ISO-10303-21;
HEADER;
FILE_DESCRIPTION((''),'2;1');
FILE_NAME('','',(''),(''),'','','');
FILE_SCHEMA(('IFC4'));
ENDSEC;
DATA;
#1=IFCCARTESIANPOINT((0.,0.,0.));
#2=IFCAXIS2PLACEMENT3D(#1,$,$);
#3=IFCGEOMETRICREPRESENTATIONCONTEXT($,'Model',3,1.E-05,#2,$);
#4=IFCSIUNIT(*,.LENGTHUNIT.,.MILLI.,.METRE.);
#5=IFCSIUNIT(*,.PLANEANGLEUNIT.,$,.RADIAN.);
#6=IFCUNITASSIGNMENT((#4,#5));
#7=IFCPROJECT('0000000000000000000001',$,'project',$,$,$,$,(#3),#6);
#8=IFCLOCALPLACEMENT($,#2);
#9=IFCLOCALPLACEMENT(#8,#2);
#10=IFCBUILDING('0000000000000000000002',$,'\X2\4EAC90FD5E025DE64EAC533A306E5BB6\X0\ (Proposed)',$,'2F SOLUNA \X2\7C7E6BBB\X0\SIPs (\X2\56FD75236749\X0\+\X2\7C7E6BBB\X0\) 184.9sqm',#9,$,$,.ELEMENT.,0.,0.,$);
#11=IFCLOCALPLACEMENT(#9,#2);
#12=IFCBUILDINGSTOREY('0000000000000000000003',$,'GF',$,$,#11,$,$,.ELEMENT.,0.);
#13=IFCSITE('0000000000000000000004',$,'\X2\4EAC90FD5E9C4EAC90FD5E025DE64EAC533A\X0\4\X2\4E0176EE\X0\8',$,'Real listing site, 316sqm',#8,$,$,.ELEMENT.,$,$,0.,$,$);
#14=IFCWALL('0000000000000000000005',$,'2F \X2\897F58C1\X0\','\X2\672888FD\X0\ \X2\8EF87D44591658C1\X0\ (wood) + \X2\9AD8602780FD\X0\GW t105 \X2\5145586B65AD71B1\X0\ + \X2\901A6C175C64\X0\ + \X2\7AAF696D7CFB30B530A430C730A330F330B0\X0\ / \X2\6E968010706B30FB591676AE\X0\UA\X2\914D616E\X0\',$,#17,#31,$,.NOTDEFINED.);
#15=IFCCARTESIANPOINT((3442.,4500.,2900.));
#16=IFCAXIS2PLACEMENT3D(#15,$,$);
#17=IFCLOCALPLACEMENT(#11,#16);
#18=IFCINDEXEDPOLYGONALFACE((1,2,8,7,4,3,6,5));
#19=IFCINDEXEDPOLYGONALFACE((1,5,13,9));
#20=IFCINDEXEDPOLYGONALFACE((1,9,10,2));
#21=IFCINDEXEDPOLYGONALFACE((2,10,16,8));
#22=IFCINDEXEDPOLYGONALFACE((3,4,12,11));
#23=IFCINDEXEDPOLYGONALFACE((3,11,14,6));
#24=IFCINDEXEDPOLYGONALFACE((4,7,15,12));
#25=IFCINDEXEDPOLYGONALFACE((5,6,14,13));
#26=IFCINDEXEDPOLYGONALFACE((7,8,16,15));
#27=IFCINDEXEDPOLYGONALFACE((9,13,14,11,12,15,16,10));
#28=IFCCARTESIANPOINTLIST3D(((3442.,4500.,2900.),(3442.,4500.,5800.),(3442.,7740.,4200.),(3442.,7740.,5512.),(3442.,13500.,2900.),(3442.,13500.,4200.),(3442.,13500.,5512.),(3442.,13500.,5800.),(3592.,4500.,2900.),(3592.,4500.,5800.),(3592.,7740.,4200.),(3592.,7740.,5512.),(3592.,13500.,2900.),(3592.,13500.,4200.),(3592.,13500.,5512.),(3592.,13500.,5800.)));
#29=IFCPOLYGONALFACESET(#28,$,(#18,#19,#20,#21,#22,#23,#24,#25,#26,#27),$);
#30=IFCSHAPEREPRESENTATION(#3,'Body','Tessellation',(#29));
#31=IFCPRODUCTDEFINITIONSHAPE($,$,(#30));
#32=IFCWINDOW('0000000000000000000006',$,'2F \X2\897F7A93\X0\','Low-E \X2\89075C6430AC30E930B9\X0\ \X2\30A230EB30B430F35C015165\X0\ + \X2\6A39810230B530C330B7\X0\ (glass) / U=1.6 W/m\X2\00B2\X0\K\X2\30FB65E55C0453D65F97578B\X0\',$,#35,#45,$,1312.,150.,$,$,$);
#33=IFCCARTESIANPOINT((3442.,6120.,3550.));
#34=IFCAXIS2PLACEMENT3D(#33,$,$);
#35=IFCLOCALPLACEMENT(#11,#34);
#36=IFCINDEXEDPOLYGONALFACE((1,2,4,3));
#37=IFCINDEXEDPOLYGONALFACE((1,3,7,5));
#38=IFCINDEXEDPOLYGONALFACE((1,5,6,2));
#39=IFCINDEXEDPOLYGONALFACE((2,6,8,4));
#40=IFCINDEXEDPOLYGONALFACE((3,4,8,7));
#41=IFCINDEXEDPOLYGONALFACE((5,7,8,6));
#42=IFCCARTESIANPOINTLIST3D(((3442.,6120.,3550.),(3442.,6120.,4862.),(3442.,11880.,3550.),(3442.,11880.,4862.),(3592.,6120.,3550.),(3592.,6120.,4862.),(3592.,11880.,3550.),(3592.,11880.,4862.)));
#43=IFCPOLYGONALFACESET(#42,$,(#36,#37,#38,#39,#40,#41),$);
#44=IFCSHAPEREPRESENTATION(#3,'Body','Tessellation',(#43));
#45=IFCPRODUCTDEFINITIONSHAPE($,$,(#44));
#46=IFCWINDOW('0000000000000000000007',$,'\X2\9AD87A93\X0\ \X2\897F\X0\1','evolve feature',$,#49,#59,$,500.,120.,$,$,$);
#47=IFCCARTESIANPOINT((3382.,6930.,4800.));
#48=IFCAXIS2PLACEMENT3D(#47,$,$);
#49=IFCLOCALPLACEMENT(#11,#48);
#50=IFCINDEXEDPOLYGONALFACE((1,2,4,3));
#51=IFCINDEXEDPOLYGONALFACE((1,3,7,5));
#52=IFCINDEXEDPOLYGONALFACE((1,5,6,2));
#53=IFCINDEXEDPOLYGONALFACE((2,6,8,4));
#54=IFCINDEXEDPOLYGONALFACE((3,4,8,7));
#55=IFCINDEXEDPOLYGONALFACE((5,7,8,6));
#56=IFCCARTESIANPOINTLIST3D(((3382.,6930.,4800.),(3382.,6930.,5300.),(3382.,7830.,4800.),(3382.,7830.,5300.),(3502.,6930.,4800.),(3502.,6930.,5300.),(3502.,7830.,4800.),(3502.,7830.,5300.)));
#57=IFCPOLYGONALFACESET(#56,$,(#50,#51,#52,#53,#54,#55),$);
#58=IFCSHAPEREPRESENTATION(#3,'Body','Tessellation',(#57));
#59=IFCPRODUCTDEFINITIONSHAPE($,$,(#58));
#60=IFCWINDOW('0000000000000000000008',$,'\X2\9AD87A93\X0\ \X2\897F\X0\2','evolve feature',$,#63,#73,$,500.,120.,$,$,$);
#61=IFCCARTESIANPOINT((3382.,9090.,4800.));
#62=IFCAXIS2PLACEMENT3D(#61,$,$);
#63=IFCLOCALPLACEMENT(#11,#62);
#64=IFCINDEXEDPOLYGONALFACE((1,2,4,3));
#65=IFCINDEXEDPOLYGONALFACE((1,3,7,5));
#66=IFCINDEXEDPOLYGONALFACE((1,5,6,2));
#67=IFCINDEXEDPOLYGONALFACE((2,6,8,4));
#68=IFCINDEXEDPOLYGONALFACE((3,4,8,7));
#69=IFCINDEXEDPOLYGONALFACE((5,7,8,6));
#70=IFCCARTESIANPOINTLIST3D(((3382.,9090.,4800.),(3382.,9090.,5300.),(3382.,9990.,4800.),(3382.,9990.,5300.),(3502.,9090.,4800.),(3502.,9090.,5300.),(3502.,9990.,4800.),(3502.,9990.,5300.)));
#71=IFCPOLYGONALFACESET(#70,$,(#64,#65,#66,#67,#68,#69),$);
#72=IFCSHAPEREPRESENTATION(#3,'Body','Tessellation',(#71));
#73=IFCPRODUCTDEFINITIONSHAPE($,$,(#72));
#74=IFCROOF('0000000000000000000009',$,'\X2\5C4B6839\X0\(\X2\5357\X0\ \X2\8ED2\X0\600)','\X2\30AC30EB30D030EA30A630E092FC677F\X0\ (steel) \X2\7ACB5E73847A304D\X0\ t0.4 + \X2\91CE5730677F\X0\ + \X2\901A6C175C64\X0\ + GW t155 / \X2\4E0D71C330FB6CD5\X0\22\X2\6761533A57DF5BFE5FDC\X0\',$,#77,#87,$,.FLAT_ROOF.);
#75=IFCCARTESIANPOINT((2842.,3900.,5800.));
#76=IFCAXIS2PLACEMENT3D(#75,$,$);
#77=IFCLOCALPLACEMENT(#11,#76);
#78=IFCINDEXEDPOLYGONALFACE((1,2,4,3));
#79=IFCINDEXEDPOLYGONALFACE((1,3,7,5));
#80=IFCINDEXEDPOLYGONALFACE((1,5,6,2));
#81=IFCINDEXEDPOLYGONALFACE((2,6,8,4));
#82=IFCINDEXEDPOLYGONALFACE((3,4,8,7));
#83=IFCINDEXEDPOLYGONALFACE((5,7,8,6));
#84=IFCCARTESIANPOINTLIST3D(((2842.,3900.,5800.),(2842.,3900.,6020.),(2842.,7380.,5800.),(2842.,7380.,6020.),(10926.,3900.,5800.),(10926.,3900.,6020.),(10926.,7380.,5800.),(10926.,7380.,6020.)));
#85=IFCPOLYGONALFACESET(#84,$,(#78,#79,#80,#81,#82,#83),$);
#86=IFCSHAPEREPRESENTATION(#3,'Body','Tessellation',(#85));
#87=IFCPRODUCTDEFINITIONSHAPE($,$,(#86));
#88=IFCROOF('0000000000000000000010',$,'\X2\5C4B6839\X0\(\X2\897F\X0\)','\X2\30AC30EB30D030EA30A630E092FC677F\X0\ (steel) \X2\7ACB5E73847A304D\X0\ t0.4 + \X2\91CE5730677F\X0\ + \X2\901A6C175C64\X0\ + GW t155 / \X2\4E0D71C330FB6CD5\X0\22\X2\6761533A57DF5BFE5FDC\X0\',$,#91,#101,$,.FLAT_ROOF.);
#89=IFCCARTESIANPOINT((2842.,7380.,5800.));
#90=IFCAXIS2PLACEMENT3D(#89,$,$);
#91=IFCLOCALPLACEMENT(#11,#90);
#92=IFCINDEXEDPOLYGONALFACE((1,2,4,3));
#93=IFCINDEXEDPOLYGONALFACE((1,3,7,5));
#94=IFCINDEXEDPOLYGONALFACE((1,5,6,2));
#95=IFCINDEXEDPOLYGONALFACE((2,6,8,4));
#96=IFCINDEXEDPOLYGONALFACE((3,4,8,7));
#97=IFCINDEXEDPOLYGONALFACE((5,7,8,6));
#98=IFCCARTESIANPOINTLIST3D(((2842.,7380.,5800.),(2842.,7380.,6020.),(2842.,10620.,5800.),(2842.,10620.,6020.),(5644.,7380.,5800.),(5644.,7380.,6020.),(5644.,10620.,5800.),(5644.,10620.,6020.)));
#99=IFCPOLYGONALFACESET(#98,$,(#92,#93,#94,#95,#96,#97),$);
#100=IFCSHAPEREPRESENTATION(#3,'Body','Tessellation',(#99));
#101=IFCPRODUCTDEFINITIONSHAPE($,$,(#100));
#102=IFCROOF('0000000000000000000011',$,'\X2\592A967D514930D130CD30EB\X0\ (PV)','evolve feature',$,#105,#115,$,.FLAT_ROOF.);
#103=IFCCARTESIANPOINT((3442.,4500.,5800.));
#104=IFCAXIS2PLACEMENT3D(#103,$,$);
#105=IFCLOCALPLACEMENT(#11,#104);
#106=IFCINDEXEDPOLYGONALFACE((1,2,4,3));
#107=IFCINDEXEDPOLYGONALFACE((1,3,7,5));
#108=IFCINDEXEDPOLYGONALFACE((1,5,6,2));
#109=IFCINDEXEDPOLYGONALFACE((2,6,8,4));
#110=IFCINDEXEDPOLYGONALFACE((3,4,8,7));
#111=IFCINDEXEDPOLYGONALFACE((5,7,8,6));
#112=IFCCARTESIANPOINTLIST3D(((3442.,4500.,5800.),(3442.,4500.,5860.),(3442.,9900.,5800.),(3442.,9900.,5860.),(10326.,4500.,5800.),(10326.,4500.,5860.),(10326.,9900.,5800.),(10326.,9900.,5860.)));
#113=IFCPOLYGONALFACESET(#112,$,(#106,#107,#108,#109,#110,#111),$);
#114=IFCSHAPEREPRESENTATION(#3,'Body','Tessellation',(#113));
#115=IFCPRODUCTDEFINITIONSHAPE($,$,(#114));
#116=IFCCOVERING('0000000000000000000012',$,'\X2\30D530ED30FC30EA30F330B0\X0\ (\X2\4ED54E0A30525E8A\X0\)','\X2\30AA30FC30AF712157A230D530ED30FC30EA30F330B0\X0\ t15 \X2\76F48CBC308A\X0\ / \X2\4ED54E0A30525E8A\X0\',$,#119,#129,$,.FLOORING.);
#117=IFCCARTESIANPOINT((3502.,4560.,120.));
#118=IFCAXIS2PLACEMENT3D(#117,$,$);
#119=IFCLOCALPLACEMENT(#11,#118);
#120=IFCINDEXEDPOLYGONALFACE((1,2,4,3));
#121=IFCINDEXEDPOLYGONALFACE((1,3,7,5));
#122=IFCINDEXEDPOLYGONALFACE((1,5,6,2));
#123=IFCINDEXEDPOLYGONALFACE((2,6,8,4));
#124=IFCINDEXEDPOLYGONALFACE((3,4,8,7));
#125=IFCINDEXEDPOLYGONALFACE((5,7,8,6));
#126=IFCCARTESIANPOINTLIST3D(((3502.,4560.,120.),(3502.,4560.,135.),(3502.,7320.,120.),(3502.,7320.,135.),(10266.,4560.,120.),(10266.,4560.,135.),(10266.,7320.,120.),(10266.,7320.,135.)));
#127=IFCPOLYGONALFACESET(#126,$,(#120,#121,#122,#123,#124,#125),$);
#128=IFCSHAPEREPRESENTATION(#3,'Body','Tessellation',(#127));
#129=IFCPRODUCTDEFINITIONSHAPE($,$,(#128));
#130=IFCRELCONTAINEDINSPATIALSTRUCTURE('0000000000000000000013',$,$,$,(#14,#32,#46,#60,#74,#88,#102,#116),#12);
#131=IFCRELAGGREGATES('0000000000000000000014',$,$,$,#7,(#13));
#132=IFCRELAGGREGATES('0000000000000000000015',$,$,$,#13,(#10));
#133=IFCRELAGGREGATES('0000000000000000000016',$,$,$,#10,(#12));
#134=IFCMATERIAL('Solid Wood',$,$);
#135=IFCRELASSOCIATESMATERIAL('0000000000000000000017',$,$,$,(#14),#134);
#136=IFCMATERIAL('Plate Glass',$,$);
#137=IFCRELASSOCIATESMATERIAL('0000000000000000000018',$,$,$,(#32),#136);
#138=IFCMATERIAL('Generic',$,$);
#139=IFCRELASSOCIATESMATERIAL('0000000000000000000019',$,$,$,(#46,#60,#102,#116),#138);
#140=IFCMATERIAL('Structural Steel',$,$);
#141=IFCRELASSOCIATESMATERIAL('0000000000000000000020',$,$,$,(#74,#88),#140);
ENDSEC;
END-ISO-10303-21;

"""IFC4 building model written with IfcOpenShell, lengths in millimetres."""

from ifc_helpers import new_model, si_unit, frame, frame_2d, origin, place, context, project, spatial, rectangle, extrude, material, element, fill, save


model = new_model("IFC4")

# Units and contexts
model_context = context("Model", 3, precision=1e-05, world=origin())
ifc_project = project(units=[si_unit("LENGTHUNIT", "METRE", prefix="MILLI"), si_unit("PLANEANGLEUNIT", "RADIAN")], contexts=[model_context])

# Site, building, storey
site_placement = place(None, origin())
site = spatial("IfcSite", under=ifc_project, at=site_placement, Name="京都府京都市左京区4丁目8", ObjectType="Real listing site, 316sqm", CompositionType="ELEMENT", RefElevation=0.0)
building_placement = place(site_placement, origin())
building = spatial("IfcBuilding", under=site, at=building_placement, Name="京都市左京区の家 (Proposed)", ObjectType="2F SOLUNA 籾殻SIPs (国産杉+籾殻) 184.9sqm", CompositionType="ELEMENT", ElevationOfRefHeight=0.0, ElevationOfTerrain=0.0)
storey_placement = place(building_placement, origin())
storey = spatial("IfcBuildingStorey", under=building, at=storey_placement, Name="GF", CompositionType="ELEMENT", Elevation=0.0)

# Shared definitions
ifc_material_1 = material(Name="Solid Wood")
ifc_material_2 = material(Name="Generic")

# Shared definitions
ifc_material_3 = material(Name="Plate Glass")

# Wall, openings, windows
wall_1_placement = place(storey_placement, frame((3442.0, 4500.0, 2900.0)))
wall_1 = element("IfcWall", 1, at=wall_1_placement, inside=storey, material=ifc_material_1, Name="2F 西壁", Description="木製 軸組外壁 (wood) + 高性能GW t105 充填断熱 + 通気層 + 窯業系サイディング / 準耐火・外皮UA配慮", PredefinedType="NOTDEFINED", context=model_context, shape_type="SweptSolid", body=[
    extrude(rectangle(XDim=150.0, YDim=9000.0, at=frame_2d((75.0, 4500.0))), frame((3442.0, 4500.0, 2900.0)), (0.0, 0.0, 1.0), 2900.0),
])
opening_1_placement = place(storey_placement, frame((3442.0, 6120.0, 3550.0)))
opening_1 = element("IfcOpeningElement", 2, at=opening_1_placement, cuts=wall_1, PredefinedType="NOTDEFINED", context=model_context, shape_type="SweptSolid", body=[
    extrude(rectangle(XDim=150.0, YDim=5760.0, at=frame_2d((75.0, 2880.0))), frame((3442.0, 6120.0, 3550.0)), (0.0, 0.0, 1.0), 1312.0),
])
opening_2_placement = place(storey_placement, frame((3382.0, 6930.0, 4800.0)))
opening_2 = element("IfcOpeningElement", 3, at=opening_2_placement, cuts=wall_1, PredefinedType="NOTDEFINED", context=model_context, shape_type="SweptSolid", body=[
    extrude(rectangle(XDim=120.0, YDim=900.0, at=frame_2d((60.0, 450.0))), frame((3382.0, 6930.0, 4800.0)), (0.0, 0.0, 1.0), 500.0),
])
opening_3_placement = place(storey_placement, frame((3382.0, 9090.0, 4800.0)))
opening_3 = element("IfcOpeningElement", 4, at=opening_3_placement, cuts=wall_1, PredefinedType="NOTDEFINED", context=model_context, shape_type="SweptSolid", body=[
    extrude(rectangle(XDim=120.0, YDim=900.0, at=frame_2d((60.0, 450.0))), frame((3382.0, 9090.0, 4800.0)), (0.0, 0.0, 1.0), 500.0),
])
window_1_placement = place(storey_placement, frame((3442.0, 6120.0, 3550.0)))
window_1 = element("IfcWindow", 5, at=window_1_placement, inside=storey, material=ifc_material_3, Name="2F 西窓", Description="Low-E 複層ガラス アルゴン封入 + 樹脂サッシ (glass) / U=1.6 W/m²K・日射取得型", OverallHeight=1312.0, OverallWidth=150.0, context=model_context, shape_type="SweptSolid", body=[
    extrude(rectangle(XDim=150.0, YDim=5760.0, at=frame_2d((75.0, 2880.0))), frame((3442.0, 6120.0, 3550.0)), (0.0, 0.0, 1.0), 1312.0),
])
fill(opening_1, window_1)
window_2_placement = place(storey_placement, frame((3382.0, 6930.0, 4800.0)))
window_2 = element("IfcWindow", 6, at=window_2_placement, inside=storey, material=ifc_material_2, Name="高窓 西1", Description="evolve feature", OverallHeight=500.0, OverallWidth=120.0, context=model_context, shape_type="SweptSolid", body=[
    extrude(rectangle(XDim=120.0, YDim=900.0, at=frame_2d((60.0, 450.0))), frame((3382.0, 6930.0, 4800.0)), (0.0, 0.0, 1.0), 500.0),
])
fill(opening_2, window_2)
window_3_placement = place(storey_placement, frame((3382.0, 9090.0, 4800.0)))
window_3 = element("IfcWindow", 7, at=window_3_placement, inside=storey, material=ifc_material_2, Name="高窓 西2", Description="evolve feature", OverallHeight=500.0, OverallWidth=120.0, context=model_context, shape_type="SweptSolid", body=[
    extrude(rectangle(XDim=120.0, YDim=900.0, at=frame_2d((60.0, 450.0))), frame((3382.0, 9090.0, 4800.0)), (0.0, 0.0, 1.0), 500.0),
])
fill(opening_3, window_3)

# Roofs
ifc_material_4 = material(Name="Structural Steel")
roof_1_placement = place(storey_placement, frame((2842.0, 3900.0, 5800.0)))
element("IfcRoof", 8, at=roof_1_placement, inside=storey, material=ifc_material_4, Name="屋根(南 軒600)", Description="ガルバリウム鋼板 (steel) 立平葺き t0.4 + 野地板 + 通気層 + GW t155 / 不燃・法22条区域対応", PredefinedType="FLAT_ROOF", context=model_context, shape_type="SweptSolid", body=[
    extrude(rectangle(XDim=8084.0, YDim=3480.0, at=frame_2d((4042.0, 1740.0))), frame((2842.0, 3900.0, 5800.0)), (0.0, 0.0, 1.0), 220.0),
])
roof_2_placement = place(storey_placement, frame((2842.0, 7380.0, 5800.0)))
element("IfcRoof", 9, at=roof_2_placement, inside=storey, material=ifc_material_4, Name="屋根(西)", Description="ガルバリウム鋼板 (steel) 立平葺き t0.4 + 野地板 + 通気層 + GW t155 / 不燃・法22条区域対応", PredefinedType="FLAT_ROOF", context=model_context, shape_type="SweptSolid", body=[
    extrude(rectangle(XDim=2802.0, YDim=3240.0, at=frame_2d((1401.0, 1620.0))), frame((2842.0, 7380.0, 5800.0)), (0.0, 0.0, 1.0), 220.0),
])
roof_3_placement = place(storey_placement, frame((3442.0, 4500.0, 5800.0)))
element("IfcRoof", 10, at=roof_3_placement, inside=storey, material=ifc_material_2, Name="太陽光パネル (PV)", Description="evolve feature", PredefinedType="FLAT_ROOF", context=model_context, shape_type="SweptSolid", body=[
    extrude(rectangle(XDim=6884.0, YDim=5400.0, at=frame_2d((3442.0, 2700.0))), frame((3442.0, 4500.0, 5800.0)), (0.0, 0.0, 1.0), 60.0),
])

# Covering
covering_placement = place(storey_placement, frame((3502.0, 4560.0, 120.0)))
element("IfcCovering", 11, at=covering_placement, inside=storey, material=ifc_material_2, Name="フローリング (仕上げ床)", Description="オーク無垢フローリング t15 直貼り / 仕上げ床", PredefinedType="FLOORING", context=model_context, shape_type="SweptSolid", body=[
    extrude(rectangle(XDim=6764.0, YDim=2760.0, at=frame_2d((3382.0, 1380.0))), frame((3502.0, 4560.0, 120.0)), (0.0, 0.0, 1.0), 15.0),
])

save(model, "model.ifc")
